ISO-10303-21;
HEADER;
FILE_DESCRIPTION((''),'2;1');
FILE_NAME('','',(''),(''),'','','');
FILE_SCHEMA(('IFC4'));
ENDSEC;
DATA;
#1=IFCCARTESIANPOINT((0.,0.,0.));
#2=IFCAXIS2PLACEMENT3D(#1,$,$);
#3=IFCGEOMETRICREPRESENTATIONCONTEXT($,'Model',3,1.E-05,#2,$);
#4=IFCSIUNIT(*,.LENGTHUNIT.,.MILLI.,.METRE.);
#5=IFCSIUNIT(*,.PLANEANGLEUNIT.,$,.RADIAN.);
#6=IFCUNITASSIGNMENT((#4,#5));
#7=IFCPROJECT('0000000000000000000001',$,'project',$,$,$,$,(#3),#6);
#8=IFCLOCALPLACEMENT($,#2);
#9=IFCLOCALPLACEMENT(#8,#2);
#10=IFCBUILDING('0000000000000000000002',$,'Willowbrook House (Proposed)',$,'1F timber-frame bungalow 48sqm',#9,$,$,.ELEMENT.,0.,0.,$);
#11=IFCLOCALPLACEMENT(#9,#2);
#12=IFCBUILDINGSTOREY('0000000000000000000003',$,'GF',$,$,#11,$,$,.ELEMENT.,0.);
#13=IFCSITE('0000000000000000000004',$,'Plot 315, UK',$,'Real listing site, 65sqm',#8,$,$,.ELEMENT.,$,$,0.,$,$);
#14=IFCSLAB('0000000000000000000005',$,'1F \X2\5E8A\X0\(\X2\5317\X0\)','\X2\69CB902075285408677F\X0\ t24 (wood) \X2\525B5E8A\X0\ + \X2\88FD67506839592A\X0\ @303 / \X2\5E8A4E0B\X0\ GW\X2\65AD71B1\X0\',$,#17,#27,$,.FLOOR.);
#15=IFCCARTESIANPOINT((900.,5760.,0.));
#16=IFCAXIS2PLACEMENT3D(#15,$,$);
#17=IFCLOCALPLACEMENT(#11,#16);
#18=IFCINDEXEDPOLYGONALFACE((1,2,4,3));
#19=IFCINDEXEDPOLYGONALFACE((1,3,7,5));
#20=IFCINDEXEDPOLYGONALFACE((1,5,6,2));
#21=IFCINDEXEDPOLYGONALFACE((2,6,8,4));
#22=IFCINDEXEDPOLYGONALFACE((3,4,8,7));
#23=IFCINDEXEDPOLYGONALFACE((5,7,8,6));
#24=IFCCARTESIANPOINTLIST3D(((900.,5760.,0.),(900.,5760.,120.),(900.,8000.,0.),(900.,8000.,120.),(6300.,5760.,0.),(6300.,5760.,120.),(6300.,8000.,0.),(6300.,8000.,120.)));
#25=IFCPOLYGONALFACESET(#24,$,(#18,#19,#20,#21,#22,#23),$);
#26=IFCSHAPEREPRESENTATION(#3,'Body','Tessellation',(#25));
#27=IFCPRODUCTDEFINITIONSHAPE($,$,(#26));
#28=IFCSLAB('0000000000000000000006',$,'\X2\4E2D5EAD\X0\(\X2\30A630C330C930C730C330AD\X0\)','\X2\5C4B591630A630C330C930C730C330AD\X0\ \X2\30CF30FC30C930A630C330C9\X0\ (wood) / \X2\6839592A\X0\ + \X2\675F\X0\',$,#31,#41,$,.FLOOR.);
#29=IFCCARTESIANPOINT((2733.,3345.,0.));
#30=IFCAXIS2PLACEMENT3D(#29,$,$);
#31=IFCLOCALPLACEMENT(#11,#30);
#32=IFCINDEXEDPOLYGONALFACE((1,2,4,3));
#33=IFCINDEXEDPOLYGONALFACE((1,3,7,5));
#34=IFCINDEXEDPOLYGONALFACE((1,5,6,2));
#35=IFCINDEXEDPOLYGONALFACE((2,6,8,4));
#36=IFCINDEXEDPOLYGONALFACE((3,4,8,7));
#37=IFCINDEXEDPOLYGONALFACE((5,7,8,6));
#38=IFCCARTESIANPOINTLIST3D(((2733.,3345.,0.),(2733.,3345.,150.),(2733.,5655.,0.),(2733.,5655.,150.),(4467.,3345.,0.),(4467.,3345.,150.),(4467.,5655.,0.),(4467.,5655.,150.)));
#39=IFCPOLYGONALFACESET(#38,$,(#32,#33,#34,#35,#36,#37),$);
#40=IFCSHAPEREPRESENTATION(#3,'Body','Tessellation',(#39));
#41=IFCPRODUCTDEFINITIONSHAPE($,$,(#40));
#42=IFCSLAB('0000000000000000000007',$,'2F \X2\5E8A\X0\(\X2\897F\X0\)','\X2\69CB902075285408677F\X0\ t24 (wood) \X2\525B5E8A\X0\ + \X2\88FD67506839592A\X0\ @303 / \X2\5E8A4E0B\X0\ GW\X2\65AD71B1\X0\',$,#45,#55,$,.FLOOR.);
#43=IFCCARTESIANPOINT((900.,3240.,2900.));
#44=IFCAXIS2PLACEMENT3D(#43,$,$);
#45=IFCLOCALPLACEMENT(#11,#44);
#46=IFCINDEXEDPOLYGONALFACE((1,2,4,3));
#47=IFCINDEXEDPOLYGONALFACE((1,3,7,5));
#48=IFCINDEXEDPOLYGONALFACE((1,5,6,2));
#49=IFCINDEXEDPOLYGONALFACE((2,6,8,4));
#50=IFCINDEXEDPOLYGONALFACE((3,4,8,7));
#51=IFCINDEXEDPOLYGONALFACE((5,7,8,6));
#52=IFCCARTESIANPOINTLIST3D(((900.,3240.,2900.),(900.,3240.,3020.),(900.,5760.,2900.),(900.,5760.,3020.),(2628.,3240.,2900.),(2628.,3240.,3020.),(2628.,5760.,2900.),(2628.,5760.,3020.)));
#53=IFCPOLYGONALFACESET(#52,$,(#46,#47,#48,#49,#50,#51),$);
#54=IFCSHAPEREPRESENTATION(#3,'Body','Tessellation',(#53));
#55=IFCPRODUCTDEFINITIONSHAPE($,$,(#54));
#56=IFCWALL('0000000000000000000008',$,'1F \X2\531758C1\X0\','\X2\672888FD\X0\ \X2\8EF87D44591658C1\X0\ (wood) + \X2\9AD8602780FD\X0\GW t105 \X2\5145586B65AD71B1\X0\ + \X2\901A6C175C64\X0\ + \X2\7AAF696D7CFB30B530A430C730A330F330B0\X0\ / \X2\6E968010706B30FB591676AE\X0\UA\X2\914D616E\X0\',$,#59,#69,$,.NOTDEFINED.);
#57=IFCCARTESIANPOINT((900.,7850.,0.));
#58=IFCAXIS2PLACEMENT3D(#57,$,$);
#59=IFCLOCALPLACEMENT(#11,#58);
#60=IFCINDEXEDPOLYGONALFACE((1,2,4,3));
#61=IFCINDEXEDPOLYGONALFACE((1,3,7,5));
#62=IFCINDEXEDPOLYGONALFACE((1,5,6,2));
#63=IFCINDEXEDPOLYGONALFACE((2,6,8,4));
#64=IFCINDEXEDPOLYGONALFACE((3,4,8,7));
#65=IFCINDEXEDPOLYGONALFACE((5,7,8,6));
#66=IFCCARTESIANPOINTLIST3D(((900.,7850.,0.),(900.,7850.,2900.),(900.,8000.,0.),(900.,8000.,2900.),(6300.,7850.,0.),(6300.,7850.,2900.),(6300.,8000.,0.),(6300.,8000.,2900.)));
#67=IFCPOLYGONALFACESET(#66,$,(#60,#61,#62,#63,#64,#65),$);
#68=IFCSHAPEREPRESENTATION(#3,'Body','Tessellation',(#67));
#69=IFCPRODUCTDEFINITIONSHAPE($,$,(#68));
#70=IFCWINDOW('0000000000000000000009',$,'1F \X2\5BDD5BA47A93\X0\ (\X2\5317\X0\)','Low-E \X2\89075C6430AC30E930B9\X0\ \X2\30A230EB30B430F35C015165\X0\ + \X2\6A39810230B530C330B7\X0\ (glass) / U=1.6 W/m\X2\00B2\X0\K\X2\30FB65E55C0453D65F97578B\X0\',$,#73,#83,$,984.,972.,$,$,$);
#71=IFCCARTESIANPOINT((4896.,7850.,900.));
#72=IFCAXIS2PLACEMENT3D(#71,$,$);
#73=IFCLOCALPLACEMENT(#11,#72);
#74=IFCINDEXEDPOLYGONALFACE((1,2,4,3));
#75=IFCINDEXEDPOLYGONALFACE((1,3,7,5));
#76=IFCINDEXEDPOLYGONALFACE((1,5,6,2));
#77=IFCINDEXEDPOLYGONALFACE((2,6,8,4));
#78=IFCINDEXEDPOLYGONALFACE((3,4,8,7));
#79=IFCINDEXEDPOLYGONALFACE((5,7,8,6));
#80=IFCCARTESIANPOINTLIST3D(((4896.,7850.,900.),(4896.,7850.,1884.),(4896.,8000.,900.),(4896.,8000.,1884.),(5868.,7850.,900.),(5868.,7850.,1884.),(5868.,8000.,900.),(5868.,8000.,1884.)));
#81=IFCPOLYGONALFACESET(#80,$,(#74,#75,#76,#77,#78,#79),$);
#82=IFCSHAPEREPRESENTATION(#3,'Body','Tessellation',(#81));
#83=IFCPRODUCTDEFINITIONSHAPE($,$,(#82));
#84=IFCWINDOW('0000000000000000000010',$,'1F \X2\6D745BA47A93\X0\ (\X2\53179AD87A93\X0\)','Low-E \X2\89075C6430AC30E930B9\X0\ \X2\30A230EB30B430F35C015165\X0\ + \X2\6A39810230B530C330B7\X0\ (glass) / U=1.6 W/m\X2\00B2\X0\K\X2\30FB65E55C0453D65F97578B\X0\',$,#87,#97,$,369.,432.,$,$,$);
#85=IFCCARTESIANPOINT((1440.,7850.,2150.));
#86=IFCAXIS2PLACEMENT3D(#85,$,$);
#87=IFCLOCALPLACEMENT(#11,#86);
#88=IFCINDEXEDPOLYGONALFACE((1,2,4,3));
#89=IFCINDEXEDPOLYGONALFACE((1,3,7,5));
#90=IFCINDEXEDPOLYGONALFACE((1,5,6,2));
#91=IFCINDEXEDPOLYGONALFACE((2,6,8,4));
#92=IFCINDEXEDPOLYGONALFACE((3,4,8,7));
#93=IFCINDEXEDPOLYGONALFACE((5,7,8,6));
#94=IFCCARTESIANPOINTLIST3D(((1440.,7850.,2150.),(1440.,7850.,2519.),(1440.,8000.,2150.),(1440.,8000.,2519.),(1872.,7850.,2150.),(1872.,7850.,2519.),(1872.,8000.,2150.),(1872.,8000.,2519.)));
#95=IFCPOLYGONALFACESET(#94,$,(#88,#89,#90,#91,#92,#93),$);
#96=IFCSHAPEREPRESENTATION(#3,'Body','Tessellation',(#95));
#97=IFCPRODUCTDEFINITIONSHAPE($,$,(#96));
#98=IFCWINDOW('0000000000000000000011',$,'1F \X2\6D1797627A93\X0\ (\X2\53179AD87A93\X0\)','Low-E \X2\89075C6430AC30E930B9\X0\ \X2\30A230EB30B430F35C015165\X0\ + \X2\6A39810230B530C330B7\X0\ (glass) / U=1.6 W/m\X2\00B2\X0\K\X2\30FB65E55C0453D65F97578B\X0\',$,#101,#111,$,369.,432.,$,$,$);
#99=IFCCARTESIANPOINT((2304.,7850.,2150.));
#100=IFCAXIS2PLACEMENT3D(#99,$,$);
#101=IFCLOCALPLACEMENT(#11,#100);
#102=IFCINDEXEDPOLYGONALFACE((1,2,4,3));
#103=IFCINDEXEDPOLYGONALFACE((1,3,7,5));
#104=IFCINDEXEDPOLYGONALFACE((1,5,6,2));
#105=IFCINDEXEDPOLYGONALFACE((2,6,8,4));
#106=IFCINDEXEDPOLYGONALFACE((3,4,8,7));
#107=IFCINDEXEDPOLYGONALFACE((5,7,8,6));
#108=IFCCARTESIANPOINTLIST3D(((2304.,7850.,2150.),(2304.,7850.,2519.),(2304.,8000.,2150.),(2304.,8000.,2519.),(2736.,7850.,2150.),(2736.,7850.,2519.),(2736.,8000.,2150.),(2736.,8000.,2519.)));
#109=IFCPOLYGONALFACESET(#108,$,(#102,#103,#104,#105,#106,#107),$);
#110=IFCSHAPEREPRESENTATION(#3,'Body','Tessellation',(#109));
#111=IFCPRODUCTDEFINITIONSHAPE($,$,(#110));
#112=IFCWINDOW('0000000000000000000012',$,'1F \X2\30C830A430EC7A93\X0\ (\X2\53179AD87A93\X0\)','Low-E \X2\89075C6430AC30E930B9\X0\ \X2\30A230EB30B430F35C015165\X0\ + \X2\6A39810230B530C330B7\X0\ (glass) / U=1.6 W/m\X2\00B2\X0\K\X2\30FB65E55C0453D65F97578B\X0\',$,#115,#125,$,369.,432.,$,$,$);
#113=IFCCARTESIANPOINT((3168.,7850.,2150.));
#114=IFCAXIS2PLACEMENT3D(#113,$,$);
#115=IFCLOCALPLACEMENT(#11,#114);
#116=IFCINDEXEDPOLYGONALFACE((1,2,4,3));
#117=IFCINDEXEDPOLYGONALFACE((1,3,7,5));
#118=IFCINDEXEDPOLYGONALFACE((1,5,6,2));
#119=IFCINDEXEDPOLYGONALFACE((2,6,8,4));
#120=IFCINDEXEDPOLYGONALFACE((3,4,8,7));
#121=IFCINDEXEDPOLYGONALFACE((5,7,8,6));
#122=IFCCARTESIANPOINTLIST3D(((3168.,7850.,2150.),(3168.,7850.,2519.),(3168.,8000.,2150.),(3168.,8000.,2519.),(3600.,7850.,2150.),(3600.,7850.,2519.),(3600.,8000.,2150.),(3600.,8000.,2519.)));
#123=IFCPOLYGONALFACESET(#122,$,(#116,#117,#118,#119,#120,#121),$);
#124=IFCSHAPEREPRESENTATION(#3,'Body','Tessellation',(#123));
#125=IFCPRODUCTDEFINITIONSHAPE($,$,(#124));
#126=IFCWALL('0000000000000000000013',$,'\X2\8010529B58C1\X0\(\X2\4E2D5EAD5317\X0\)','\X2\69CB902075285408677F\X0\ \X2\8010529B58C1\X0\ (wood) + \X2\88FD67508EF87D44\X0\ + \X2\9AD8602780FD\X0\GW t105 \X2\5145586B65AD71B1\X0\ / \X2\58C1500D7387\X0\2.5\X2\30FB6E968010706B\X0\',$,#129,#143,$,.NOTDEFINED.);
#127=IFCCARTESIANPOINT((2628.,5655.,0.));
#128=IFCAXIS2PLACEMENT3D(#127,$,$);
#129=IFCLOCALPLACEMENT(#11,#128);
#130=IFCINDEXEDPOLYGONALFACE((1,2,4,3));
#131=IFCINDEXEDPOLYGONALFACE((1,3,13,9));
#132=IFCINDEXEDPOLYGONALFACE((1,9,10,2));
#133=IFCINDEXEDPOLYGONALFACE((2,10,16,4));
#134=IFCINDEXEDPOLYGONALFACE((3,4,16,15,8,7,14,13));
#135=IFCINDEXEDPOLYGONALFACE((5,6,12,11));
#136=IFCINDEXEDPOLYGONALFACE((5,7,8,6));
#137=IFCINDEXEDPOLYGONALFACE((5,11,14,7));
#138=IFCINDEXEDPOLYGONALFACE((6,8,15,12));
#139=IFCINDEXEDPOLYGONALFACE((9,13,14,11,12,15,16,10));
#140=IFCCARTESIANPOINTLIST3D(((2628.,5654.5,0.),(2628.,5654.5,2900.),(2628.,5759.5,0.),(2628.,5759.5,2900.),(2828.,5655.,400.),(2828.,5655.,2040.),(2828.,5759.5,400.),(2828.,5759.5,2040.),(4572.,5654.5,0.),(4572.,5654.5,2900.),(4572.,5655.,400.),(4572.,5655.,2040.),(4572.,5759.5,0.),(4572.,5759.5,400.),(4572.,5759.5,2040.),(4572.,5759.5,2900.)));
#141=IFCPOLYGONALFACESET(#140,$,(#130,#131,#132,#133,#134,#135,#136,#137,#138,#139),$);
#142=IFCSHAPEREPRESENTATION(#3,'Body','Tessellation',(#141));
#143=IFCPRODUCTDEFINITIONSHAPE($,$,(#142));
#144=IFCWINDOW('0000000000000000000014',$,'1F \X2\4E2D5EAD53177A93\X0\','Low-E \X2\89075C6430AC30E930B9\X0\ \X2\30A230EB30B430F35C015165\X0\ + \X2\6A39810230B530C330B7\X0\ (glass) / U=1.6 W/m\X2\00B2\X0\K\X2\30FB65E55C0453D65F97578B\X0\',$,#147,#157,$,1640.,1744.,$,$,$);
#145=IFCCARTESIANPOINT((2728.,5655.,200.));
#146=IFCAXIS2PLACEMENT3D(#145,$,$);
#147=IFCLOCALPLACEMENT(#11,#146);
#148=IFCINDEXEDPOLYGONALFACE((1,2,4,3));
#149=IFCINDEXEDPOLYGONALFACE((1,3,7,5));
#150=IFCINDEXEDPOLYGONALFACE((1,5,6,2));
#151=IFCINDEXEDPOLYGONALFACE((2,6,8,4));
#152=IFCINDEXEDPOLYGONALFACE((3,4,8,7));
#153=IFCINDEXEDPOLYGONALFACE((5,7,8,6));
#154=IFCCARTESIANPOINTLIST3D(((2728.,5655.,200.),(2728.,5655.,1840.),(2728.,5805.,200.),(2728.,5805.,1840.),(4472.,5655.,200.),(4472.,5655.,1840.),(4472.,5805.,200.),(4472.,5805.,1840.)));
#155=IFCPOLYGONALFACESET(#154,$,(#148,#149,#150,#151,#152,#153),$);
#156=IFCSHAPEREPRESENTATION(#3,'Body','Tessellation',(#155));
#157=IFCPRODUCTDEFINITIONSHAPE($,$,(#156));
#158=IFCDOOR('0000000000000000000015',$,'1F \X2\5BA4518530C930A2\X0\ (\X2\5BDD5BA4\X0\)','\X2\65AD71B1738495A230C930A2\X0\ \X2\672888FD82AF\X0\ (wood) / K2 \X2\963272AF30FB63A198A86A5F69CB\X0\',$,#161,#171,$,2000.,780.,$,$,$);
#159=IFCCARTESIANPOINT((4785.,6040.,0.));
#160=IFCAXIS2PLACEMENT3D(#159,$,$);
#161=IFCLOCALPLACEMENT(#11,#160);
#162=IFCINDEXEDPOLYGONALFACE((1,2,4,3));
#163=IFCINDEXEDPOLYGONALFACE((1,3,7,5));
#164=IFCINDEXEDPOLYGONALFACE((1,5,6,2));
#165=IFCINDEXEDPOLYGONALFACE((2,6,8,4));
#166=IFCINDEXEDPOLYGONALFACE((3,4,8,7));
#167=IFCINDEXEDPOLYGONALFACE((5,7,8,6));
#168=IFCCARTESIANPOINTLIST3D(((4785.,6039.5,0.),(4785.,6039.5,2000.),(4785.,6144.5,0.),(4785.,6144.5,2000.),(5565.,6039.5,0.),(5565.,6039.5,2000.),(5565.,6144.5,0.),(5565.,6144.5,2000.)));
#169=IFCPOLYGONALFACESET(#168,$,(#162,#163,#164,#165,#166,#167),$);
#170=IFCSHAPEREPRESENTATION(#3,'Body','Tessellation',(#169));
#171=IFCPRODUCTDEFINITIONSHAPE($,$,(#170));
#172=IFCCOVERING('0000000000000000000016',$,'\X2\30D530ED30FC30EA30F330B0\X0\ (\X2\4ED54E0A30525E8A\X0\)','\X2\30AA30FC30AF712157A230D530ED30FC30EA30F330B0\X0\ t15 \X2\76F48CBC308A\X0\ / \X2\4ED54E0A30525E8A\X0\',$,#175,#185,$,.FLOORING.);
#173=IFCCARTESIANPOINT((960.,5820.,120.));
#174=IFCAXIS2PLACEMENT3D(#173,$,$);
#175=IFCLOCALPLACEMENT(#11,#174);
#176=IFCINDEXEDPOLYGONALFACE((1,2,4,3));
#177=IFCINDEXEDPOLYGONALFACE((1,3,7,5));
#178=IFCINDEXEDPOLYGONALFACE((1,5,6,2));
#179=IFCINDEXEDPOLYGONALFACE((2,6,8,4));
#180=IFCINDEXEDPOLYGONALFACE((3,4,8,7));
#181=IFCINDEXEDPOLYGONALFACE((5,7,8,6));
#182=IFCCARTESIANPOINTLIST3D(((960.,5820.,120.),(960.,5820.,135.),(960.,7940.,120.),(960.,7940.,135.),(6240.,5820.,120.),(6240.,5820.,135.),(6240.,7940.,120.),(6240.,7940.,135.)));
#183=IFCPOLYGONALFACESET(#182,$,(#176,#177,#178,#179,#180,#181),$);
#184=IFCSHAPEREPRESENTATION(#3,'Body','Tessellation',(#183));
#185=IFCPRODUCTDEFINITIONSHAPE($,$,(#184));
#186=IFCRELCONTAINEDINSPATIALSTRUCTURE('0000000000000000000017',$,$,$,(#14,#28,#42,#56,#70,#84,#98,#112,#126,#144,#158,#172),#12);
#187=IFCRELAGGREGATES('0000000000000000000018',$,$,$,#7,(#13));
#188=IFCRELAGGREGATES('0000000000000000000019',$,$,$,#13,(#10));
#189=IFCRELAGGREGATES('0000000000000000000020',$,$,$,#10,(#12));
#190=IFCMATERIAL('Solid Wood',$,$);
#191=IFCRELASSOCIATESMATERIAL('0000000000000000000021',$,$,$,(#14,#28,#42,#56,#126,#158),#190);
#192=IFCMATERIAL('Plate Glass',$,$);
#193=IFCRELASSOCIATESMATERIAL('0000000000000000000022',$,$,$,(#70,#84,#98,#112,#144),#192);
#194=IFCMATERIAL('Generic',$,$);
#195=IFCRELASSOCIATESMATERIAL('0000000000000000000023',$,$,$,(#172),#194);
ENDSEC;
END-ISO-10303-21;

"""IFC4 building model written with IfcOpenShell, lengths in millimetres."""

from ifc_helpers import new_model, si_unit, frame, frame_2d, origin, place, context, project, spatial, rectangle, extrude, material, element, fill, save


model = new_model("IFC4")

# Units and contexts
model_context = context("Model", 3, precision=1e-05, world=origin())
ifc_project = project(units=[si_unit("LENGTHUNIT", "METRE", prefix="MILLI"), si_unit("PLANEANGLEUNIT", "RADIAN")], contexts=[model_context])

# Site, building, storey
site_placement = place(None, origin())
site = spatial("IfcSite", under=ifc_project, at=site_placement, Name="Plot 315, UK", ObjectType="Real listing site, 65sqm", CompositionType="ELEMENT", RefElevation=0.0)
building_placement = place(site_placement, origin())
building = spatial("IfcBuilding", under=site, at=building_placement, Name="Willowbrook House (Proposed)", ObjectType="1F timber-frame bungalow 48sqm", CompositionType="ELEMENT", ElevationOfRefHeight=0.0, ElevationOfTerrain=0.0)
storey_placement = place(building_placement, origin())
storey = spatial("IfcBuildingStorey", under=building, at=storey_placement, Name="GF", CompositionType="ELEMENT", Elevation=0.0)

# Slabs
ifc_material_1 = material(Name="Solid Wood")
slab_1_placement = place(storey_placement, frame((900.0, 5760.0, 0.0)))
element("IfcSlab", 1, at=slab_1_placement, inside=storey, material=ifc_material_1, Name="1F 床(北)", Description="構造用合板 t24 (wood) 剛床 + 製材根太 @303 / 床下 GW断熱", PredefinedType="FLOOR", context=model_context, shape_type="SweptSolid", body=[
    extrude(rectangle(XDim=5400.0, YDim=2240.0, at=frame_2d((2700.0, 1120.0))), frame((900.0, 5760.0, 0.0)), (0.0, 0.0, 1.0), 120.0),
])
slab_2_placement = place(storey_placement, frame((2733.0, 3345.0, 0.0)))
element("IfcSlab", 2, at=slab_2_placement, inside=storey, material=ifc_material_1, Name="中庭(ウッドデッキ)", Description="屋外ウッドデッキ ハードウッド (wood) / 根太 + 束", PredefinedType="FLOOR", context=model_context, shape_type="SweptSolid", body=[
    extrude(rectangle(XDim=1734.0, YDim=2310.0, at=frame_2d((867.0, 1155.0))), frame((2733.0, 3345.0, 0.0)), (0.0, 0.0, 1.0), 150.0),
])
slab_3_placement = place(storey_placement, frame((900.0, 3240.0, 2900.0)))
element("IfcSlab", 3, at=slab_3_placement, inside=storey, material=ifc_material_1, Name="2F 床(西)", Description="構造用合板 t24 (wood) 剛床 + 製材根太 @303 / 床下 GW断熱", PredefinedType="FLOOR", context=model_context, shape_type="SweptSolid", body=[
    extrude(rectangle(XDim=1728.0, YDim=2520.0, at=frame_2d((864.0, 1260.0))), frame((900.0, 3240.0, 2900.0)), (0.0, 0.0, 1.0), 120.0),
])

# Wall, openings, windows
wall_1_placement = place(storey_placement, frame((900.0, 7850.0, 0.0)))
wall_1 = element("IfcWall", 4, at=wall_1_placement, inside=storey, material=ifc_material_1, Name="1F 北壁", Description="木製 軸組外壁 (wood) + 高性能GW t105 充填断熱 + 通気層 + 窯業系サイディング / 準耐火・外皮UA配慮", PredefinedType="NOTDEFINED", context=model_context, shape_type="SweptSolid", body=[
    extrude(rectangle(XDim=5400.0, YDim=150.0, at=frame_2d((2700.0, 75.0))), frame((900.0, 7850.0, 0.0)), (0.0, 0.0, 1.0), 2900.0),
])
opening_1_placement = place(storey_placement, frame((4896.0, 7850.0, 900.0)))
opening_1 = element("IfcOpeningElement", 5, at=opening_1_placement, cuts=wall_1, PredefinedType="NOTDEFINED", context=model_context, shape_type="SweptSolid", body=[
    extrude(rectangle(XDim=972.0, YDim=150.0, at=frame_2d((486.0, 75.0))), frame((4896.0, 7850.0, 900.0)), (0.0, 0.0, 1.0), 984.0),
])
opening_2_placement = place(storey_placement, frame((1440.0, 7850.0, 2150.0)))
opening_2 = element("IfcOpeningElement", 6, at=opening_2_placement, cuts=wall_1, PredefinedType="NOTDEFINED", context=model_context, shape_type="SweptSolid", body=[
    extrude(rectangle(XDim=432.0, YDim=150.0, at=frame_2d((216.0, 75.0))), frame((1440.0, 7850.0, 2150.0)), (0.0, 0.0, 1.0), 369.0),
])
opening_3_placement = place(storey_placement, frame((2304.0, 7850.0, 2150.0)))
opening_3 = element("IfcOpeningElement", 7, at=opening_3_placement, cuts=wall_1, PredefinedType="NOTDEFINED", context=model_context, shape_type="SweptSolid", body=[
    extrude(rectangle(XDim=432.0, YDim=150.0, at=frame_2d((216.0, 75.0))), frame((2304.0, 7850.0, 2150.0)), (0.0, 0.0, 1.0), 369.0),
])
opening_4_placement = place(storey_placement, frame((3168.0, 7850.0, 2150.0)))
opening_4 = element("IfcOpeningElement", 8, at=opening_4_placement, cuts=wall_1, PredefinedType="NOTDEFINED", context=model_context, shape_type="SweptSolid", body=[
    extrude(rectangle(XDim=432.0, YDim=150.0, at=frame_2d((216.0, 75.0))), frame((3168.0, 7850.0, 2150.0)), (0.0, 0.0, 1.0), 369.0),
])
ifc_material_2 = material(Name="Plate Glass")
window_1_placement = place(storey_placement, frame((4896.0, 7850.0, 900.0)))
window_1 = element("IfcWindow", 9, at=window_1_placement, inside=storey, material=ifc_material_2, Name="1F 寝室窓 (北)", Description="Low-E 複層ガラス アルゴン封入 + 樹脂サッシ (glass) / U=1.6 W/m²K・日射取得型", OverallHeight=984.0, OverallWidth=972.0, context=model_context, shape_type="SweptSolid", body=[
    extrude(rectangle(XDim=972.0, YDim=150.0, at=frame_2d((486.0, 75.0))), frame((4896.0, 7850.0, 900.0)), (0.0, 0.0, 1.0), 984.0),
])
fill(opening_1, window_1)
window_2_placement = place(storey_placement, frame((1440.0, 7850.0, 2150.0)))
window_2 = element("IfcWindow", 10, at=window_2_placement, inside=storey, material=ifc_material_2, Name="1F 浴室窓 (北高窓)", Description="Low-E 複層ガラス アルゴン封入 + 樹脂サッシ (glass) / U=1.6 W/m²K・日射取得型", OverallHeight=369.0, OverallWidth=432.0, context=model_context, shape_type="SweptSolid", body=[
    extrude(rectangle(XDim=432.0, YDim=150.0, at=frame_2d((216.0, 75.0))), frame((1440.0, 7850.0, 2150.0)), (0.0, 0.0, 1.0), 369.0),
])
fill(opening_2, window_2)
window_3_placement = place(storey_placement, frame((2304.0, 7850.0, 2150.0)))
window_3 = element("IfcWindow", 11, at=window_3_placement, inside=storey, material=ifc_material_2, Name="1F 洗面窓 (北高窓)", Description="Low-E 複層ガラス アルゴン封入 + 樹脂サッシ (glass) / U=1.6 W/m²K・日射取得型", OverallHeight=369.0, OverallWidth=432.0, context=model_context, shape_type="SweptSolid", body=[
    extrude(rectangle(XDim=432.0, YDim=150.0, at=frame_2d((216.0, 75.0))), frame((2304.0, 7850.0, 2150.0)), (0.0, 0.0, 1.0), 369.0),
])
fill(opening_3, window_3)
window_4_placement = place(storey_placement, frame((3168.0, 7850.0, 2150.0)))
window_4 = element("IfcWindow", 12, at=window_4_placement, inside=storey, material=ifc_material_2, Name="1F トイレ窓 (北高窓)", Description="Low-E 複層ガラス アルゴン封入 + 樹脂サッシ (glass) / U=1.6 W/m²K・日射取得型", OverallHeight=369.0, OverallWidth=432.0, context=model_context, shape_type="SweptSolid", body=[
    extrude(rectangle(XDim=432.0, YDim=150.0, at=frame_2d((216.0, 75.0))), frame((3168.0, 7850.0, 2150.0)), (0.0, 0.0, 1.0), 369.0),
])
fill(opening_4, window_4)

# Wall, opening, window
wall_2_placement = place(storey_placement, frame((2628.0, 5655.0, 0.0)))
wall_2 = element("IfcWall", 13, at=wall_2_placement, inside=storey, material=ifc_material_1, Name="耐力壁(中庭北)", Description="構造用合板 耐力壁 (wood) + 製材軸組 + 高性能GW t105 充填断熱 / 壁倍率2.5・準耐火", PredefinedType="NOTDEFINED", context=model_context, shape_type="SweptSolid", body=[
    extrude(rectangle(XDim=1944.0, YDim=105.0, at=frame_2d((972.0, 52.0))), frame((2628.0, 5655.0, 0.0)), (0.0, 0.0, 1.0), 2900.0),
])
opening_5_placement = place(storey_placement, frame((2728.0, 5655.0, 200.0)))
opening_5 = element("IfcOpeningElement", 14, at=opening_5_placement, cuts=wall_2, PredefinedType="NOTDEFINED", context=model_context, shape_type="SweptSolid", body=[
    extrude(rectangle(XDim=1744.0, YDim=150.0, at=frame_2d((872.0, 75.0))), frame((2728.0, 5655.0, 200.0)), (0.0, 0.0, 1.0), 1640.0),
])
window_5_placement = place(storey_placement, frame((2728.0, 5655.0, 200.0)))
window_5 = element("IfcWindow", 15, at=window_5_placement, inside=storey, material=ifc_material_2, Name="1F 中庭北窓", Description="Low-E 複層ガラス アルゴン封入 + 樹脂サッシ (glass) / U=1.6 W/m²K・日射取得型", OverallHeight=1640.0, OverallWidth=1744.0, context=model_context, shape_type="SweptSolid", body=[
    extrude(rectangle(XDim=1744.0, YDim=150.0, at=frame_2d((872.0, 75.0))), frame((2728.0, 5655.0, 200.0)), (0.0, 0.0, 1.0), 1640.0),
])
fill(opening_5, window_5)

# Door
door_1_placement = place(storey_placement, frame((4785.0, 6040.0, 0.0)))
element("IfcDoor", 16, at=door_1_placement, inside=storey, material=ifc_material_1, Name="1F 室内ドア (寝室)", Description="断熱玄関ドア 木製芯 (wood) / K2 防犯・採風機構", OverallHeight=2000.0, OverallWidth=780.0, context=model_context, shape_type="SweptSolid", body=[
    extrude(rectangle(XDim=780.0, YDim=105.0, at=frame_2d((390.0, 52.0))), frame((4785.0, 6040.0, 0.0)), (0.0, 0.0, 1.0), 2000.0),
])

# Covering
ifc_material_3 = material(Name="Generic")
covering_1_placement = place(storey_placement, frame((960.0, 5820.0, 120.0)))
element("IfcCovering", 17, at=covering_1_placement, inside=storey, material=ifc_material_3, Name="フローリング (仕上げ床)", Description="オーク無垢フローリング t15 直貼り / 仕上げ床", PredefinedType="FLOORING", context=model_context, shape_type="SweptSolid", body=[
    extrude(rectangle(XDim=5280.0, YDim=2120.0, at=frame_2d((2640.0, 1060.0))), frame((960.0, 5820.0, 120.0)), (0.0, 0.0, 1.0), 15.0),
])

save(model, "model.ifc")
